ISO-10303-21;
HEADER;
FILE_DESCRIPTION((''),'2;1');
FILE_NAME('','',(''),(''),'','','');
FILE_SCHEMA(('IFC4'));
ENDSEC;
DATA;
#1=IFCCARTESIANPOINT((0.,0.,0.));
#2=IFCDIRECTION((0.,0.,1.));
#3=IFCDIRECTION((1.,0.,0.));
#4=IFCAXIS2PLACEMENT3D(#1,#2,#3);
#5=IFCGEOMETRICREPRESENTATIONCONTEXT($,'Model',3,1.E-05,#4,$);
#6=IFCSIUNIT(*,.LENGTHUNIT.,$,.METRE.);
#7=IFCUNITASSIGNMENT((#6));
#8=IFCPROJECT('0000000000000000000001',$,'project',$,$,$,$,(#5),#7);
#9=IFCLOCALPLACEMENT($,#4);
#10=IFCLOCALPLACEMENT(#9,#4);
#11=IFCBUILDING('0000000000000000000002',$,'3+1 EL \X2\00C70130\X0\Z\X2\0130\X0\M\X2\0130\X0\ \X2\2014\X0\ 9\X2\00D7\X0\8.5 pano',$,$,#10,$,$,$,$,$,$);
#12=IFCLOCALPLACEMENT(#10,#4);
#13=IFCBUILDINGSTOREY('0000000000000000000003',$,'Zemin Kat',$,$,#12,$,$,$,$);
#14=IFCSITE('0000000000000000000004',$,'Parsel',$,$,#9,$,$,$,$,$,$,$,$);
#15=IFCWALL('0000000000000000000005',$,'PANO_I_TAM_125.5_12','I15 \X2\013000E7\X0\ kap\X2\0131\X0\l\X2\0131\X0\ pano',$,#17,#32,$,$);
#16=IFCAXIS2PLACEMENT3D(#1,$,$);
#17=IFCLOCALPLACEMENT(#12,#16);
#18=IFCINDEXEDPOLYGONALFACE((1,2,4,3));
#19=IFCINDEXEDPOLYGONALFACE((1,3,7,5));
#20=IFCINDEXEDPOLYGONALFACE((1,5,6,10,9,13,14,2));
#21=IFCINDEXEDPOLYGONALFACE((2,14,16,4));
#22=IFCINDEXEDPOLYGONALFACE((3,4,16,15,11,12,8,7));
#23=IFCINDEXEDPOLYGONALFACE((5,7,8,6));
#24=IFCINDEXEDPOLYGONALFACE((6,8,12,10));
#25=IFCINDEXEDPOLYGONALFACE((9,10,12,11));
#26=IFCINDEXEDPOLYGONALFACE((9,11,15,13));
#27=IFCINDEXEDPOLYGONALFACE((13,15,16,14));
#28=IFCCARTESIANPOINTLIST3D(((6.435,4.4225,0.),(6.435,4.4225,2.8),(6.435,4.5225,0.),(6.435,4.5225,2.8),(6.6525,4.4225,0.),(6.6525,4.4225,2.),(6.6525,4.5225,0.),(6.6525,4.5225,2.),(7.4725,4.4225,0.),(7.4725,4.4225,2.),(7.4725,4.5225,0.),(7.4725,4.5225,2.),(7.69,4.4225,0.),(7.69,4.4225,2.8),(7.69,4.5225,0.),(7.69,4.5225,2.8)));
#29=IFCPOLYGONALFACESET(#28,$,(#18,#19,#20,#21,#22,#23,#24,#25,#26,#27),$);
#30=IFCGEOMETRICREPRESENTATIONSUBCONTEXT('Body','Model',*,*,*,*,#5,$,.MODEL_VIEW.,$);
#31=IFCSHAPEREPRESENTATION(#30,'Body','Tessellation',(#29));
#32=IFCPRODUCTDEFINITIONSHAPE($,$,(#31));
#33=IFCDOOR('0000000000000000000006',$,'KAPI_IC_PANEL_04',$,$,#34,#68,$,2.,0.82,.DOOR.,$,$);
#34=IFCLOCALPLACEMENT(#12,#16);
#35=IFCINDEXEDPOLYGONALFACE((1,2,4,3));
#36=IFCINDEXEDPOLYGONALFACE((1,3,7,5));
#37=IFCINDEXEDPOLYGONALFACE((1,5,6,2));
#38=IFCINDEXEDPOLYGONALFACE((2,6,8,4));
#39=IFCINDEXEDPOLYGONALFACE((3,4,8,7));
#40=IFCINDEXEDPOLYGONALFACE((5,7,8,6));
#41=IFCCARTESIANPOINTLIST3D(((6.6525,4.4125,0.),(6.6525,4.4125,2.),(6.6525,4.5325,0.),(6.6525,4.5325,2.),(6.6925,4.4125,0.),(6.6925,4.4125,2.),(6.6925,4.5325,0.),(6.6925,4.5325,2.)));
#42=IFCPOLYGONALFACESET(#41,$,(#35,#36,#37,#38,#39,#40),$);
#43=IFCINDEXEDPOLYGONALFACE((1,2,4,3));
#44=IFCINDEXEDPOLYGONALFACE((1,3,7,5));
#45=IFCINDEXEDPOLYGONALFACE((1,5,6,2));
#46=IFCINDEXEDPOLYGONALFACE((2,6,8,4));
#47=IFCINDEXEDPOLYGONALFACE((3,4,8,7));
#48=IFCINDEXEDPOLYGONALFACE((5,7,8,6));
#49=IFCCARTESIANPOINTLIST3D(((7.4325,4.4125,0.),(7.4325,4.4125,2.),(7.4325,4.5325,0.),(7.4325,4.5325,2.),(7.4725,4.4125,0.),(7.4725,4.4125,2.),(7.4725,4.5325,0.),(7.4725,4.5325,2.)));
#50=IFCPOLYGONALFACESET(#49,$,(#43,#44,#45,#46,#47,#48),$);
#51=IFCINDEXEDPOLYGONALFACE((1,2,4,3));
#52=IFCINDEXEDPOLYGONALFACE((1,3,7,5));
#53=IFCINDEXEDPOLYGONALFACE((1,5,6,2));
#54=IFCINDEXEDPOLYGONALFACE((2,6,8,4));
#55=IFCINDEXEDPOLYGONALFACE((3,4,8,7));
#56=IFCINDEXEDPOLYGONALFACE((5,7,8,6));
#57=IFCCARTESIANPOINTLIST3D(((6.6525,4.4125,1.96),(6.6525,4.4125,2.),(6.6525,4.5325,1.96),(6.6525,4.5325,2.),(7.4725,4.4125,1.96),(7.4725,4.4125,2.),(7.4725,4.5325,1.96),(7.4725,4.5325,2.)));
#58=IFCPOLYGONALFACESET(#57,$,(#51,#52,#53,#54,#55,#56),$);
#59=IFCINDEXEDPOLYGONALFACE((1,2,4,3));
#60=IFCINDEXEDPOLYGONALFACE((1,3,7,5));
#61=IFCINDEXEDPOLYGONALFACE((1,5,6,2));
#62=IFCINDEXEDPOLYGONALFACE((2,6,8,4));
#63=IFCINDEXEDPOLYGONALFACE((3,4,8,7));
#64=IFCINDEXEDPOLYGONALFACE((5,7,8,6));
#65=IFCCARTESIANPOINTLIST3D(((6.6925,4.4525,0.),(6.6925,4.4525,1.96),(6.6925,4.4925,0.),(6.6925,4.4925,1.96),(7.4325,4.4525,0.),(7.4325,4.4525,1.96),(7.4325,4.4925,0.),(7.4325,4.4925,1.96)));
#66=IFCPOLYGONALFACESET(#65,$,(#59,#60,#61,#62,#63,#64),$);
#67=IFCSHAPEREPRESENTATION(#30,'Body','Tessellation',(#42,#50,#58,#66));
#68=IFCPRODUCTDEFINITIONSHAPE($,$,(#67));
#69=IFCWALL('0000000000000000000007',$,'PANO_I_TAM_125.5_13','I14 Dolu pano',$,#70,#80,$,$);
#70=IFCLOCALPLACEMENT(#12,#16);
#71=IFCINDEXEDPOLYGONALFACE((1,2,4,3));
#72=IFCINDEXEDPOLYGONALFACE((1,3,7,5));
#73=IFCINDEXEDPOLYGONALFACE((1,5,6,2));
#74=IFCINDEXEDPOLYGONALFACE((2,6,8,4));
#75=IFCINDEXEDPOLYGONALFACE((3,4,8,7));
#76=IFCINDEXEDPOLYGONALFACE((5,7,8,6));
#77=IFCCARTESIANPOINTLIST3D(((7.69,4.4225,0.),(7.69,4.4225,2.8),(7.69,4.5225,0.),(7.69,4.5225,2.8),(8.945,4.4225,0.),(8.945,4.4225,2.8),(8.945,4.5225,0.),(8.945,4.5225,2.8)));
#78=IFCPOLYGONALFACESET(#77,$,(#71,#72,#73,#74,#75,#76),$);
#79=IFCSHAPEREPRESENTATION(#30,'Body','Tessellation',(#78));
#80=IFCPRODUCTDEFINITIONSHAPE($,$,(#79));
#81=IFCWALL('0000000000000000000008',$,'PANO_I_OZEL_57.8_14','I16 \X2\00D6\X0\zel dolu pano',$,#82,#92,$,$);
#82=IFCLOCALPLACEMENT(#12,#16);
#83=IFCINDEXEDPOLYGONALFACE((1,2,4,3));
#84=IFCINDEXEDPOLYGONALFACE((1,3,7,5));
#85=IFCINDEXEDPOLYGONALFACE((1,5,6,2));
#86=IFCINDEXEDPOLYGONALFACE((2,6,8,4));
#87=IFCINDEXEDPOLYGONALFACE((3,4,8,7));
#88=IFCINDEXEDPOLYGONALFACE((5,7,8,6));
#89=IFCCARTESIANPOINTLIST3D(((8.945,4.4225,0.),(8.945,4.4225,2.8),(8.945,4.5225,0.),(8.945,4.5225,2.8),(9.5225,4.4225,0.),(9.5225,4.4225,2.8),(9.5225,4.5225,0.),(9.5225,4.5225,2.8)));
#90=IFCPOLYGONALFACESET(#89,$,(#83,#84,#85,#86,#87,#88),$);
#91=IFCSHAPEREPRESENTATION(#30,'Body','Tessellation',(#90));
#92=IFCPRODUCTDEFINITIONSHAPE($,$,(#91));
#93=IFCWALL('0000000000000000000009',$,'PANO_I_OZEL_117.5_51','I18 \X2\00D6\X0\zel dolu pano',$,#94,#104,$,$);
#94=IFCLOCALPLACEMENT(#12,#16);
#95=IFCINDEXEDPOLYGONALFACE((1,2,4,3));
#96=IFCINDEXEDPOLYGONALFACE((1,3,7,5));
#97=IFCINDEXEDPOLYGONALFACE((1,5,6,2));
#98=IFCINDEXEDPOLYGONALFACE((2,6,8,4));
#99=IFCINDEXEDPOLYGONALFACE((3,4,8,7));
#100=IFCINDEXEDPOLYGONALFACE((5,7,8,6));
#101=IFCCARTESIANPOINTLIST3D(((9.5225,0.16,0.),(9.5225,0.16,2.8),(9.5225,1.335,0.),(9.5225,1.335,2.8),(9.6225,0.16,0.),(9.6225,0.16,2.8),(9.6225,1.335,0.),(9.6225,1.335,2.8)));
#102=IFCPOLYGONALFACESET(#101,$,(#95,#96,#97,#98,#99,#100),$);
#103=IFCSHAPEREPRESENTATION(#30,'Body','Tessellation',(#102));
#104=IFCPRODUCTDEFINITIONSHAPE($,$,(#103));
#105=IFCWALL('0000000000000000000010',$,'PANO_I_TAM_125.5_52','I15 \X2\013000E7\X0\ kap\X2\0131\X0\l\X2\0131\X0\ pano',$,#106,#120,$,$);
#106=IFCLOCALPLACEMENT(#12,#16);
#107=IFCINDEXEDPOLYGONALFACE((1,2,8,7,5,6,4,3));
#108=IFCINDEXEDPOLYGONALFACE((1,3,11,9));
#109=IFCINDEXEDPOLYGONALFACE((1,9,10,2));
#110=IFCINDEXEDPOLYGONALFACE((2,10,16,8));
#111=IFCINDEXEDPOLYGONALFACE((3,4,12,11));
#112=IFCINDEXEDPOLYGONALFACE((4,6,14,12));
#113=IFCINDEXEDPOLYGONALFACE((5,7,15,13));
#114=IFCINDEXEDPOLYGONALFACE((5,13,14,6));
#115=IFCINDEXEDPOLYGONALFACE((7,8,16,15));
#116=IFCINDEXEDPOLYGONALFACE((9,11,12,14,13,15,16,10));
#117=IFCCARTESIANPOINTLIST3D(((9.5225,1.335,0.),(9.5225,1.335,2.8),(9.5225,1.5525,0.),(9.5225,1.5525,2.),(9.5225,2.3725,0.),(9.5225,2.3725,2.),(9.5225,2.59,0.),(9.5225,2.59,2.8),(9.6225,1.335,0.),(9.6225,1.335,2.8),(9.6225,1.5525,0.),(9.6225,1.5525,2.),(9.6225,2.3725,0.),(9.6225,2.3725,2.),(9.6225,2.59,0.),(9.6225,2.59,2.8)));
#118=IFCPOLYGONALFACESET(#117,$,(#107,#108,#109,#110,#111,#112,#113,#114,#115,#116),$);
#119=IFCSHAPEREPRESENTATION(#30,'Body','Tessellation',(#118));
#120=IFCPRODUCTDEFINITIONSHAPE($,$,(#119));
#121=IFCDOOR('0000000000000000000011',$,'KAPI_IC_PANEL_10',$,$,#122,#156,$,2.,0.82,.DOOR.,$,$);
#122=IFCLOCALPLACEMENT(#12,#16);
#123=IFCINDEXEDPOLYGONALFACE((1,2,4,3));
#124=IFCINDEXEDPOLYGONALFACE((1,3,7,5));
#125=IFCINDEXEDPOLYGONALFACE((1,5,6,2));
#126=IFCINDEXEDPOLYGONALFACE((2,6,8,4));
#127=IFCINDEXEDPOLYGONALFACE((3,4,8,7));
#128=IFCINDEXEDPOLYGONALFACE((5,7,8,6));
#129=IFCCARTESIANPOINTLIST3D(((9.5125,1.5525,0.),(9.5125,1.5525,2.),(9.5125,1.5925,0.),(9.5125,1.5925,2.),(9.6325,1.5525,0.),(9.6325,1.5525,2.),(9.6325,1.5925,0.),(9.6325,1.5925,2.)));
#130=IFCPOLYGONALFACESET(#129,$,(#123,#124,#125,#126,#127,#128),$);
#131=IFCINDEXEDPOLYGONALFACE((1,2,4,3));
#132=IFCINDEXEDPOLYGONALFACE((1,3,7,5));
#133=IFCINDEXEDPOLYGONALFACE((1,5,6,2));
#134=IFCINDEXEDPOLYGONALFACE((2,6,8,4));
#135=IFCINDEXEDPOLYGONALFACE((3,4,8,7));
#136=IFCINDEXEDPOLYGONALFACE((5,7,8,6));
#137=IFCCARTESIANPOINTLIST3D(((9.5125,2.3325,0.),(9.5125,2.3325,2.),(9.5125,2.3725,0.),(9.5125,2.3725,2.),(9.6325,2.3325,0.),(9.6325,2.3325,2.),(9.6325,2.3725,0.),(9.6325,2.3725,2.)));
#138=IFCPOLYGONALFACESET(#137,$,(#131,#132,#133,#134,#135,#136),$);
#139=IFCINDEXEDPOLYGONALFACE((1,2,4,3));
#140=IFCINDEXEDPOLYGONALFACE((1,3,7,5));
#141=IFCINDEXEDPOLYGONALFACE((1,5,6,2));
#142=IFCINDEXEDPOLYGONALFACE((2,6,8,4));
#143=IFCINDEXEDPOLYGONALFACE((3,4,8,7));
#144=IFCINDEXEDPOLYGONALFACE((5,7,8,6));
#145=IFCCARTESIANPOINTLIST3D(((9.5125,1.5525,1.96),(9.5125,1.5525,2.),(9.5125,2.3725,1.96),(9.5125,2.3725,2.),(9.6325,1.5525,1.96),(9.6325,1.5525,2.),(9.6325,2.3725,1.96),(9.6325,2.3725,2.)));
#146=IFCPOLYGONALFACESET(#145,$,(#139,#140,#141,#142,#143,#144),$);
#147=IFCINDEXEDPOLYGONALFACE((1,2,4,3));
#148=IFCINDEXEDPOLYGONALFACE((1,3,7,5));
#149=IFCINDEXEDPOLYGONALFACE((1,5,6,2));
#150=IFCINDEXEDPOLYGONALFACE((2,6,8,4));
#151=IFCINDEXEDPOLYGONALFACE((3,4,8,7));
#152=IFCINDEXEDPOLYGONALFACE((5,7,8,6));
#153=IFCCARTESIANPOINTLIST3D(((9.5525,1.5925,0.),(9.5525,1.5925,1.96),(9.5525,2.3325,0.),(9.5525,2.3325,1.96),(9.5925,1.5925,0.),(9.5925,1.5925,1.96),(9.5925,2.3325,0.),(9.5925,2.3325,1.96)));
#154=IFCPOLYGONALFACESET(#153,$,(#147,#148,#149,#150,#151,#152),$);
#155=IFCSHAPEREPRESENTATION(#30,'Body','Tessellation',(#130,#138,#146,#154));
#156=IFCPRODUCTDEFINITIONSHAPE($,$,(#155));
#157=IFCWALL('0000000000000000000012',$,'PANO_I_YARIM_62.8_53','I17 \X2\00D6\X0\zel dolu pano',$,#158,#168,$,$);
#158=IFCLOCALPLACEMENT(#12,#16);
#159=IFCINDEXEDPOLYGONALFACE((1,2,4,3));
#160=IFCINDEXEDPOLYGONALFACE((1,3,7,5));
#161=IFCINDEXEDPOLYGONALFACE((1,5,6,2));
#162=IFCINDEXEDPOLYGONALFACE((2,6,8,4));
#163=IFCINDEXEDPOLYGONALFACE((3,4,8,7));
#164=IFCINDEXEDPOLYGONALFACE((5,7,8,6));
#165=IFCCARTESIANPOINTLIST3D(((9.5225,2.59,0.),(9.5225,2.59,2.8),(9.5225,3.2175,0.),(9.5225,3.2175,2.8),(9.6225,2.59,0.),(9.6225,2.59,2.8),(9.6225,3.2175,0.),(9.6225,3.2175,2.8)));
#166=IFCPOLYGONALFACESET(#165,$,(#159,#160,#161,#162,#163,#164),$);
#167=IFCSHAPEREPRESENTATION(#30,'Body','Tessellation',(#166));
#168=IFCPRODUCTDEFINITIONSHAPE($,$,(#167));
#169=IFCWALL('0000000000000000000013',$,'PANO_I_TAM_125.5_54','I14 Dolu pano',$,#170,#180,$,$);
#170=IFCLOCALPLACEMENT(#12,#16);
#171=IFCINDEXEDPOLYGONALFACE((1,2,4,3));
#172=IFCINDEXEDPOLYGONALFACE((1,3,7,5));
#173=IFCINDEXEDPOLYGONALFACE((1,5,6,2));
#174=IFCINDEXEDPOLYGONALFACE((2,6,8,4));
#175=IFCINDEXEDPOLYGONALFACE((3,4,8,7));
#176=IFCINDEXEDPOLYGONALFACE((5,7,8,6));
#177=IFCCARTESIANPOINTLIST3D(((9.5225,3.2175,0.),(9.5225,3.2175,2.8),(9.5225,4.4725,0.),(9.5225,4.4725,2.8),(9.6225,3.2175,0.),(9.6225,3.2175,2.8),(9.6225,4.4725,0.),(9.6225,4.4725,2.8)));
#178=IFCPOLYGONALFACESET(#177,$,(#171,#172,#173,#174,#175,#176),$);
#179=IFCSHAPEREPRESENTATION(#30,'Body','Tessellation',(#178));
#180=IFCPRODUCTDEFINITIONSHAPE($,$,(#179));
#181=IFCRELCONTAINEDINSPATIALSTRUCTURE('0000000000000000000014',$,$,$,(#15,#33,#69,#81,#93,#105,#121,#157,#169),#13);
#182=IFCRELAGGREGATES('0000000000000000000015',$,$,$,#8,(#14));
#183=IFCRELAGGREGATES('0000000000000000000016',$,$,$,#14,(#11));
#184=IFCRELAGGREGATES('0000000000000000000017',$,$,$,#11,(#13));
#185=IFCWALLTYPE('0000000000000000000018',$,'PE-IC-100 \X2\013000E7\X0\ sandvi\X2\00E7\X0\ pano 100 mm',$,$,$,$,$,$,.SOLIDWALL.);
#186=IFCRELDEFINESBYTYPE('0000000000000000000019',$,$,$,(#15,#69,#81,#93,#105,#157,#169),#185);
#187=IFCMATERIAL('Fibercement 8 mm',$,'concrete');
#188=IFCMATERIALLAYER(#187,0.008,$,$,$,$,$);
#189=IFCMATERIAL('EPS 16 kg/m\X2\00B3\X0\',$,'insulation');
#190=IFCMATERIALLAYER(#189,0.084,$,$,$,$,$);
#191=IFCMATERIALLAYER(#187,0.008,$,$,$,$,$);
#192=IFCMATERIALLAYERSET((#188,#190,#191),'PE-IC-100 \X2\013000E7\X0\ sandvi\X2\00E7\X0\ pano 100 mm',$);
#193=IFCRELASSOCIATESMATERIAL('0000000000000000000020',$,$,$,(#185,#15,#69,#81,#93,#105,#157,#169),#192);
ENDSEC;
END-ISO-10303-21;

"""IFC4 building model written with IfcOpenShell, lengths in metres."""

from ifc_helpers import new_model, si_unit, frame, origin_with_axes, place, context, subcontext, project, spatial, line, indexed_curve, outline, extrude, material, layer, layer_set, layer_usage, type_object, element, fill, save


model = new_model("IFC4")

# Units and contexts
model_context = context("Model", 3, precision=1e-05, world=origin_with_axes())
body_context = subcontext(model_context, "Body", "Model", "MODEL_VIEW")
ifc_project = project(units=[si_unit("LENGTHUNIT", "METRE")], contexts=[model_context])

# Site, building, storey
site_placement = place(None, origin_with_axes())
site = spatial("IfcSite", under=ifc_project, at=site_placement, Name="Parsel")
building_placement = place(site_placement, origin_with_axes())
building = spatial("IfcBuilding", under=site, at=building_placement, Name="3+1 EL ÇİZİMİ — 9×8.5 pano")
storey_placement = place(building_placement, origin_with_axes())
storey = spatial("IfcBuildingStorey", under=building, at=storey_placement, Name="Zemin Kat")

# Shared definitions
ifc_material_1 = material(Name="Fibercement 8 mm", Category="concrete")
ifc_material_2 = material(Name="EPS 16 kg/m³", Category="insulation")

# Shared definitions
ifc_layer_1 = layer(ifc_material_1, 0.008)
ifc_layer_2 = layer(ifc_material_2, 0.084)
ifc_layer_3 = layer(ifc_material_1, 0.008)
ifc_layer_set_1 = layer_set([ifc_layer_1, ifc_layer_2, ifc_layer_3], Name="PE-IC-100 İç sandviç pano 100 mm")
wall_type_1 = type_object("IfcWallType", Name="PE-IC-100 İç sandviç pano 100 mm", PredefinedType="SOLIDWALL", material=ifc_layer_set_1)

# Wall, opening, door
ifc_layer_usage_1 = layer_usage(ifc_layer_set_1, "AXIS2", "POSITIVE", 0.0)
wall_1_placement = place(storey_placement, frame((6.435, 4.4225, 0.0), z_axis=(0.0, 0.0, 1.0), x_axis=(1.0, 0.0, 0.0)))
wall_1 = element("IfcWall", 1, at=wall_1_placement, inside=storey, type_object=wall_type_1, material=ifc_layer_usage_1, Name="PANO_I_TAM_125.5_12", Description="I15 İç kapılı pano", context=body_context, shape_type="SweptSolid", body=[
    extrude(outline(indexed_curve([(0.0, 0.0), (1.255, 0.0), (1.255, 0.1), (0.0, 0.1)], segments=[line(1, 2, 3, 4, 1)])), origin_with_axes(), (0.0, 0.0, 1.0), 2.8),
])
opening_1_placement = place(wall_1_placement, origin_with_axes())
opening_1 = element("IfcOpeningElement", 2, at=opening_1_placement, cuts=wall_1, PredefinedType="OPENING", context=body_context, shape_type="SweptSolid", body=[
    extrude(outline(indexed_curve([(0.0, 0.0), (0.82, 0.0), (0.82, 0.14), (0.0, 0.14)], segments=[line(1, 2, 3, 4, 1)])), frame((0.2175, -0.02, 0.0), z_axis=(0.0, 0.0, 1.0), x_axis=(1.0, 0.0, 0.0)), (0.0, 0.0, 1.0), 2.0),
])
door_1_placement = place(storey_placement, frame((6.435, 4.4225, 0.0), z_axis=(0.0, 0.0, 1.0), x_axis=(1.0, 0.0, 0.0)))
door_1 = element("IfcDoor", 3, at=door_1_placement, inside=storey, Name="KAPI_IC_PANEL_04", OverallHeight=2.0, OverallWidth=0.82, PredefinedType="DOOR", context=body_context, shape_type="SweptSolid", body=[
    extrude(outline(indexed_curve([(0.0, 0.0), (0.04, 0.0), (0.04, 0.12), (0.0, 0.12)], segments=[line(1, 2, 3, 4, 1)])), frame((0.2175, -0.01, 0.0), z_axis=(0.0, 0.0, 1.0), x_axis=(1.0, 0.0, 0.0)), (0.0, 0.0, 1.0), 2.0),
    extrude(outline(indexed_curve([(0.0, 0.0), (0.04, 0.0), (0.04, 0.12), (0.0, 0.12)], segments=[line(1, 2, 3, 4, 1)])), frame((0.9975, -0.01, 0.0), z_axis=(0.0, 0.0, 1.0), x_axis=(1.0, 0.0, 0.0)), (0.0, 0.0, 1.0), 2.0),
    extrude(outline(indexed_curve([(0.0, 0.0), (0.82, 0.0), (0.82, 0.12), (0.0, 0.12)], segments=[line(1, 2, 3, 4, 1)])), frame((0.2175, -0.01, 1.96), z_axis=(0.0, 0.0, 1.0), x_axis=(1.0, 0.0, 0.0)), (0.0, 0.0, 1.0), 0.04),
    extrude(outline(indexed_curve([(0.0, 0.0), (0.74, 0.0), (0.74, 0.04), (0.0, 0.04)], segments=[line(1, 2, 3, 4, 1)])), frame((0.2575, 0.03, 0.0), z_axis=(0.0, 0.0, 1.0), x_axis=(1.0, 0.0, 0.0)), (0.0, 0.0, 1.0), 1.96),
])
fill(opening_1, door_1)

# Walls
ifc_layer_usage_2 = layer_usage(ifc_layer_set_1, "AXIS2", "POSITIVE", 0.0)
wall_2_placement = place(storey_placement, frame((7.69, 4.4225, 0.0), z_axis=(0.0, 0.0, 1.0), x_axis=(1.0, 0.0, 0.0)))
element("IfcWall", 4, at=wall_2_placement, inside=storey, type_object=wall_type_1, material=ifc_layer_usage_2, Name="PANO_I_TAM_125.5_13", Description="I14 Dolu pano", context=body_context, shape_type="SweptSolid", body=[
    extrude(outline(indexed_curve([(0.0, 0.0), (1.255, 0.0), (1.255, 0.1), (0.0, 0.1)], segments=[line(1, 2, 3, 4, 1)])), origin_with_axes(), (0.0, 0.0, 1.0), 2.8),
])
ifc_layer_usage_3 = layer_usage(ifc_layer_set_1, "AXIS2", "POSITIVE", 0.0)
wall_3_placement = place(storey_placement, frame((8.945, 4.4225, 0.0), z_axis=(0.0, 0.0, 1.0), x_axis=(1.0, 0.0, 0.0)))
element("IfcWall", 5, at=wall_3_placement, inside=storey, type_object=wall_type_1, material=ifc_layer_usage_3, Name="PANO_I_OZEL_57.8_14", Description="I16 Özel dolu pano", context=body_context, shape_type="SweptSolid", body=[
    extrude(outline(indexed_curve([(0.0, 0.0), (0.5775, 0.0), (0.5775, 0.1), (0.0, 0.1)], segments=[line(1, 2, 3, 4, 1)])), origin_with_axes(), (0.0, 0.0, 1.0), 2.8),
])
ifc_layer_usage_4 = layer_usage(ifc_layer_set_1, "AXIS2", "POSITIVE", 0.0)
wall_4_placement = place(storey_placement, frame((9.6225, 0.16, 0.0), z_axis=(0.0, 0.0, 1.0), x_axis=(0.0, 1.0, 0.0)))
element("IfcWall", 6, at=wall_4_placement, inside=storey, type_object=wall_type_1, material=ifc_layer_usage_4, Name="PANO_I_OZEL_117.5_51", Description="I18 Özel dolu pano", context=body_context, shape_type="SweptSolid", body=[
    extrude(outline(indexed_curve([(0.0, 0.0), (1.175, 0.0), (1.175, 0.1), (0.0, 0.1)], segments=[line(1, 2, 3, 4, 1)])), origin_with_axes(), (0.0, 0.0, 1.0), 2.8),
])

# Wall, opening, door
ifc_layer_usage_5 = layer_usage(ifc_layer_set_1, "AXIS2", "POSITIVE", 0.0)
wall_5_placement = place(storey_placement, frame((9.6225, 1.335, 0.0), z_axis=(0.0, 0.0, 1.0), x_axis=(0.0, 1.0, 0.0)))
wall_5 = element("IfcWall", 7, at=wall_5_placement, inside=storey, type_object=wall_type_1, material=ifc_layer_usage_5, Name="PANO_I_TAM_125.5_52", Description="I15 İç kapılı pano", context=body_context, shape_type="SweptSolid", body=[
    extrude(outline(indexed_curve([(0.0, 0.0), (1.255, 0.0), (1.255, 0.1), (0.0, 0.1)], segments=[line(1, 2, 3, 4, 1)])), origin_with_axes(), (0.0, 0.0, 1.0), 2.8),
])
opening_2_placement = place(wall_5_placement, origin_with_axes())
opening_2 = element("IfcOpeningElement", 8, at=opening_2_placement, cuts=wall_5, PredefinedType="OPENING", context=body_context, shape_type="SweptSolid", body=[
    extrude(outline(indexed_curve([(0.0, 0.0), (0.82, 0.0), (0.82, 0.14), (0.0, 0.14)], segments=[line(1, 2, 3, 4, 1)])), frame((0.2175, -0.02, 0.0), z_axis=(0.0, 0.0, 1.0), x_axis=(1.0, 0.0, 0.0)), (0.0, 0.0, 1.0), 2.0),
])
door_2_placement = place(storey_placement, frame((9.6225, 1.335, 0.0), z_axis=(0.0, 0.0, 1.0), x_axis=(0.0, 1.0, 0.0)))
door_2 = element("IfcDoor", 9, at=door_2_placement, inside=storey, Name="KAPI_IC_PANEL_10", OverallHeight=2.0, OverallWidth=0.82, PredefinedType="DOOR", context=body_context, shape_type="SweptSolid", body=[
    extrude(outline(indexed_curve([(0.0, 0.0), (0.04, 0.0), (0.04, 0.12), (0.0, 0.12)], segments=[line(1, 2, 3, 4, 1)])), frame((0.2175, -0.01, 0.0), z_axis=(0.0, 0.0, 1.0), x_axis=(1.0, 0.0, 0.0)), (0.0, 0.0, 1.0), 2.0),
    extrude(outline(indexed_curve([(0.0, 0.0), (0.04, 0.0), (0.04, 0.12), (0.0, 0.12)], segments=[line(1, 2, 3, 4, 1)])), frame((0.9975, -0.01, 0.0), z_axis=(0.0, 0.0, 1.0), x_axis=(1.0, 0.0, 0.0)), (0.0, 0.0, 1.0), 2.0),
    extrude(outline(indexed_curve([(0.0, 0.0), (0.82, 0.0), (0.82, 0.12), (0.0, 0.12)], segments=[line(1, 2, 3, 4, 1)])), frame((0.2175, -0.01, 1.96), z_axis=(0.0, 0.0, 1.0), x_axis=(1.0, 0.0, 0.0)), (0.0, 0.0, 1.0), 0.04),
    extrude(outline(indexed_curve([(0.0, 0.0), (0.74, 0.0), (0.74, 0.04), (0.0, 0.04)], segments=[line(1, 2, 3, 4, 1)])), frame((0.2575, 0.03, 0.0), z_axis=(0.0, 0.0, 1.0), x_axis=(1.0, 0.0, 0.0)), (0.0, 0.0, 1.0), 1.96),
])
fill(opening_2, door_2)

# Walls
ifc_layer_usage_6 = layer_usage(ifc_layer_set_1, "AXIS2", "POSITIVE", 0.0)
wall_6_placement = place(storey_placement, frame((9.6225, 2.59, 0.0), z_axis=(0.0, 0.0, 1.0), x_axis=(0.0, 1.0, 0.0)))
element("IfcWall", 10, at=wall_6_placement, inside=storey, type_object=wall_type_1, material=ifc_layer_usage_6, Name="PANO_I_YARIM_62.8_53", Description="I17 Özel dolu pano", context=body_context, shape_type="SweptSolid", body=[
    extrude(outline(indexed_curve([(0.0, 0.0), (0.6275, 0.0), (0.6275, 0.1), (0.0, 0.1)], segments=[line(1, 2, 3, 4, 1)])), origin_with_axes(), (0.0, 0.0, 1.0), 2.8),
])
ifc_layer_usage_7 = layer_usage(ifc_layer_set_1, "AXIS2", "POSITIVE", 0.0)
wall_7_placement = place(storey_placement, frame((9.6225, 3.2175, 0.0), z_axis=(0.0, 0.0, 1.0), x_axis=(0.0, 1.0, 0.0)))
element("IfcWall", 11, at=wall_7_placement, inside=storey, type_object=wall_type_1, material=ifc_layer_usage_7, Name="PANO_I_TAM_125.5_54", Description="I14 Dolu pano", context=body_context, shape_type="SweptSolid", body=[
    extrude(outline(indexed_curve([(0.0, 0.0), (1.255, 0.0), (1.255, 0.1), (0.0, 0.1)], segments=[line(1, 2, 3, 4, 1)])), origin_with_axes(), (0.0, 0.0, 1.0), 2.8),
])

save(model, "model.ifc")
